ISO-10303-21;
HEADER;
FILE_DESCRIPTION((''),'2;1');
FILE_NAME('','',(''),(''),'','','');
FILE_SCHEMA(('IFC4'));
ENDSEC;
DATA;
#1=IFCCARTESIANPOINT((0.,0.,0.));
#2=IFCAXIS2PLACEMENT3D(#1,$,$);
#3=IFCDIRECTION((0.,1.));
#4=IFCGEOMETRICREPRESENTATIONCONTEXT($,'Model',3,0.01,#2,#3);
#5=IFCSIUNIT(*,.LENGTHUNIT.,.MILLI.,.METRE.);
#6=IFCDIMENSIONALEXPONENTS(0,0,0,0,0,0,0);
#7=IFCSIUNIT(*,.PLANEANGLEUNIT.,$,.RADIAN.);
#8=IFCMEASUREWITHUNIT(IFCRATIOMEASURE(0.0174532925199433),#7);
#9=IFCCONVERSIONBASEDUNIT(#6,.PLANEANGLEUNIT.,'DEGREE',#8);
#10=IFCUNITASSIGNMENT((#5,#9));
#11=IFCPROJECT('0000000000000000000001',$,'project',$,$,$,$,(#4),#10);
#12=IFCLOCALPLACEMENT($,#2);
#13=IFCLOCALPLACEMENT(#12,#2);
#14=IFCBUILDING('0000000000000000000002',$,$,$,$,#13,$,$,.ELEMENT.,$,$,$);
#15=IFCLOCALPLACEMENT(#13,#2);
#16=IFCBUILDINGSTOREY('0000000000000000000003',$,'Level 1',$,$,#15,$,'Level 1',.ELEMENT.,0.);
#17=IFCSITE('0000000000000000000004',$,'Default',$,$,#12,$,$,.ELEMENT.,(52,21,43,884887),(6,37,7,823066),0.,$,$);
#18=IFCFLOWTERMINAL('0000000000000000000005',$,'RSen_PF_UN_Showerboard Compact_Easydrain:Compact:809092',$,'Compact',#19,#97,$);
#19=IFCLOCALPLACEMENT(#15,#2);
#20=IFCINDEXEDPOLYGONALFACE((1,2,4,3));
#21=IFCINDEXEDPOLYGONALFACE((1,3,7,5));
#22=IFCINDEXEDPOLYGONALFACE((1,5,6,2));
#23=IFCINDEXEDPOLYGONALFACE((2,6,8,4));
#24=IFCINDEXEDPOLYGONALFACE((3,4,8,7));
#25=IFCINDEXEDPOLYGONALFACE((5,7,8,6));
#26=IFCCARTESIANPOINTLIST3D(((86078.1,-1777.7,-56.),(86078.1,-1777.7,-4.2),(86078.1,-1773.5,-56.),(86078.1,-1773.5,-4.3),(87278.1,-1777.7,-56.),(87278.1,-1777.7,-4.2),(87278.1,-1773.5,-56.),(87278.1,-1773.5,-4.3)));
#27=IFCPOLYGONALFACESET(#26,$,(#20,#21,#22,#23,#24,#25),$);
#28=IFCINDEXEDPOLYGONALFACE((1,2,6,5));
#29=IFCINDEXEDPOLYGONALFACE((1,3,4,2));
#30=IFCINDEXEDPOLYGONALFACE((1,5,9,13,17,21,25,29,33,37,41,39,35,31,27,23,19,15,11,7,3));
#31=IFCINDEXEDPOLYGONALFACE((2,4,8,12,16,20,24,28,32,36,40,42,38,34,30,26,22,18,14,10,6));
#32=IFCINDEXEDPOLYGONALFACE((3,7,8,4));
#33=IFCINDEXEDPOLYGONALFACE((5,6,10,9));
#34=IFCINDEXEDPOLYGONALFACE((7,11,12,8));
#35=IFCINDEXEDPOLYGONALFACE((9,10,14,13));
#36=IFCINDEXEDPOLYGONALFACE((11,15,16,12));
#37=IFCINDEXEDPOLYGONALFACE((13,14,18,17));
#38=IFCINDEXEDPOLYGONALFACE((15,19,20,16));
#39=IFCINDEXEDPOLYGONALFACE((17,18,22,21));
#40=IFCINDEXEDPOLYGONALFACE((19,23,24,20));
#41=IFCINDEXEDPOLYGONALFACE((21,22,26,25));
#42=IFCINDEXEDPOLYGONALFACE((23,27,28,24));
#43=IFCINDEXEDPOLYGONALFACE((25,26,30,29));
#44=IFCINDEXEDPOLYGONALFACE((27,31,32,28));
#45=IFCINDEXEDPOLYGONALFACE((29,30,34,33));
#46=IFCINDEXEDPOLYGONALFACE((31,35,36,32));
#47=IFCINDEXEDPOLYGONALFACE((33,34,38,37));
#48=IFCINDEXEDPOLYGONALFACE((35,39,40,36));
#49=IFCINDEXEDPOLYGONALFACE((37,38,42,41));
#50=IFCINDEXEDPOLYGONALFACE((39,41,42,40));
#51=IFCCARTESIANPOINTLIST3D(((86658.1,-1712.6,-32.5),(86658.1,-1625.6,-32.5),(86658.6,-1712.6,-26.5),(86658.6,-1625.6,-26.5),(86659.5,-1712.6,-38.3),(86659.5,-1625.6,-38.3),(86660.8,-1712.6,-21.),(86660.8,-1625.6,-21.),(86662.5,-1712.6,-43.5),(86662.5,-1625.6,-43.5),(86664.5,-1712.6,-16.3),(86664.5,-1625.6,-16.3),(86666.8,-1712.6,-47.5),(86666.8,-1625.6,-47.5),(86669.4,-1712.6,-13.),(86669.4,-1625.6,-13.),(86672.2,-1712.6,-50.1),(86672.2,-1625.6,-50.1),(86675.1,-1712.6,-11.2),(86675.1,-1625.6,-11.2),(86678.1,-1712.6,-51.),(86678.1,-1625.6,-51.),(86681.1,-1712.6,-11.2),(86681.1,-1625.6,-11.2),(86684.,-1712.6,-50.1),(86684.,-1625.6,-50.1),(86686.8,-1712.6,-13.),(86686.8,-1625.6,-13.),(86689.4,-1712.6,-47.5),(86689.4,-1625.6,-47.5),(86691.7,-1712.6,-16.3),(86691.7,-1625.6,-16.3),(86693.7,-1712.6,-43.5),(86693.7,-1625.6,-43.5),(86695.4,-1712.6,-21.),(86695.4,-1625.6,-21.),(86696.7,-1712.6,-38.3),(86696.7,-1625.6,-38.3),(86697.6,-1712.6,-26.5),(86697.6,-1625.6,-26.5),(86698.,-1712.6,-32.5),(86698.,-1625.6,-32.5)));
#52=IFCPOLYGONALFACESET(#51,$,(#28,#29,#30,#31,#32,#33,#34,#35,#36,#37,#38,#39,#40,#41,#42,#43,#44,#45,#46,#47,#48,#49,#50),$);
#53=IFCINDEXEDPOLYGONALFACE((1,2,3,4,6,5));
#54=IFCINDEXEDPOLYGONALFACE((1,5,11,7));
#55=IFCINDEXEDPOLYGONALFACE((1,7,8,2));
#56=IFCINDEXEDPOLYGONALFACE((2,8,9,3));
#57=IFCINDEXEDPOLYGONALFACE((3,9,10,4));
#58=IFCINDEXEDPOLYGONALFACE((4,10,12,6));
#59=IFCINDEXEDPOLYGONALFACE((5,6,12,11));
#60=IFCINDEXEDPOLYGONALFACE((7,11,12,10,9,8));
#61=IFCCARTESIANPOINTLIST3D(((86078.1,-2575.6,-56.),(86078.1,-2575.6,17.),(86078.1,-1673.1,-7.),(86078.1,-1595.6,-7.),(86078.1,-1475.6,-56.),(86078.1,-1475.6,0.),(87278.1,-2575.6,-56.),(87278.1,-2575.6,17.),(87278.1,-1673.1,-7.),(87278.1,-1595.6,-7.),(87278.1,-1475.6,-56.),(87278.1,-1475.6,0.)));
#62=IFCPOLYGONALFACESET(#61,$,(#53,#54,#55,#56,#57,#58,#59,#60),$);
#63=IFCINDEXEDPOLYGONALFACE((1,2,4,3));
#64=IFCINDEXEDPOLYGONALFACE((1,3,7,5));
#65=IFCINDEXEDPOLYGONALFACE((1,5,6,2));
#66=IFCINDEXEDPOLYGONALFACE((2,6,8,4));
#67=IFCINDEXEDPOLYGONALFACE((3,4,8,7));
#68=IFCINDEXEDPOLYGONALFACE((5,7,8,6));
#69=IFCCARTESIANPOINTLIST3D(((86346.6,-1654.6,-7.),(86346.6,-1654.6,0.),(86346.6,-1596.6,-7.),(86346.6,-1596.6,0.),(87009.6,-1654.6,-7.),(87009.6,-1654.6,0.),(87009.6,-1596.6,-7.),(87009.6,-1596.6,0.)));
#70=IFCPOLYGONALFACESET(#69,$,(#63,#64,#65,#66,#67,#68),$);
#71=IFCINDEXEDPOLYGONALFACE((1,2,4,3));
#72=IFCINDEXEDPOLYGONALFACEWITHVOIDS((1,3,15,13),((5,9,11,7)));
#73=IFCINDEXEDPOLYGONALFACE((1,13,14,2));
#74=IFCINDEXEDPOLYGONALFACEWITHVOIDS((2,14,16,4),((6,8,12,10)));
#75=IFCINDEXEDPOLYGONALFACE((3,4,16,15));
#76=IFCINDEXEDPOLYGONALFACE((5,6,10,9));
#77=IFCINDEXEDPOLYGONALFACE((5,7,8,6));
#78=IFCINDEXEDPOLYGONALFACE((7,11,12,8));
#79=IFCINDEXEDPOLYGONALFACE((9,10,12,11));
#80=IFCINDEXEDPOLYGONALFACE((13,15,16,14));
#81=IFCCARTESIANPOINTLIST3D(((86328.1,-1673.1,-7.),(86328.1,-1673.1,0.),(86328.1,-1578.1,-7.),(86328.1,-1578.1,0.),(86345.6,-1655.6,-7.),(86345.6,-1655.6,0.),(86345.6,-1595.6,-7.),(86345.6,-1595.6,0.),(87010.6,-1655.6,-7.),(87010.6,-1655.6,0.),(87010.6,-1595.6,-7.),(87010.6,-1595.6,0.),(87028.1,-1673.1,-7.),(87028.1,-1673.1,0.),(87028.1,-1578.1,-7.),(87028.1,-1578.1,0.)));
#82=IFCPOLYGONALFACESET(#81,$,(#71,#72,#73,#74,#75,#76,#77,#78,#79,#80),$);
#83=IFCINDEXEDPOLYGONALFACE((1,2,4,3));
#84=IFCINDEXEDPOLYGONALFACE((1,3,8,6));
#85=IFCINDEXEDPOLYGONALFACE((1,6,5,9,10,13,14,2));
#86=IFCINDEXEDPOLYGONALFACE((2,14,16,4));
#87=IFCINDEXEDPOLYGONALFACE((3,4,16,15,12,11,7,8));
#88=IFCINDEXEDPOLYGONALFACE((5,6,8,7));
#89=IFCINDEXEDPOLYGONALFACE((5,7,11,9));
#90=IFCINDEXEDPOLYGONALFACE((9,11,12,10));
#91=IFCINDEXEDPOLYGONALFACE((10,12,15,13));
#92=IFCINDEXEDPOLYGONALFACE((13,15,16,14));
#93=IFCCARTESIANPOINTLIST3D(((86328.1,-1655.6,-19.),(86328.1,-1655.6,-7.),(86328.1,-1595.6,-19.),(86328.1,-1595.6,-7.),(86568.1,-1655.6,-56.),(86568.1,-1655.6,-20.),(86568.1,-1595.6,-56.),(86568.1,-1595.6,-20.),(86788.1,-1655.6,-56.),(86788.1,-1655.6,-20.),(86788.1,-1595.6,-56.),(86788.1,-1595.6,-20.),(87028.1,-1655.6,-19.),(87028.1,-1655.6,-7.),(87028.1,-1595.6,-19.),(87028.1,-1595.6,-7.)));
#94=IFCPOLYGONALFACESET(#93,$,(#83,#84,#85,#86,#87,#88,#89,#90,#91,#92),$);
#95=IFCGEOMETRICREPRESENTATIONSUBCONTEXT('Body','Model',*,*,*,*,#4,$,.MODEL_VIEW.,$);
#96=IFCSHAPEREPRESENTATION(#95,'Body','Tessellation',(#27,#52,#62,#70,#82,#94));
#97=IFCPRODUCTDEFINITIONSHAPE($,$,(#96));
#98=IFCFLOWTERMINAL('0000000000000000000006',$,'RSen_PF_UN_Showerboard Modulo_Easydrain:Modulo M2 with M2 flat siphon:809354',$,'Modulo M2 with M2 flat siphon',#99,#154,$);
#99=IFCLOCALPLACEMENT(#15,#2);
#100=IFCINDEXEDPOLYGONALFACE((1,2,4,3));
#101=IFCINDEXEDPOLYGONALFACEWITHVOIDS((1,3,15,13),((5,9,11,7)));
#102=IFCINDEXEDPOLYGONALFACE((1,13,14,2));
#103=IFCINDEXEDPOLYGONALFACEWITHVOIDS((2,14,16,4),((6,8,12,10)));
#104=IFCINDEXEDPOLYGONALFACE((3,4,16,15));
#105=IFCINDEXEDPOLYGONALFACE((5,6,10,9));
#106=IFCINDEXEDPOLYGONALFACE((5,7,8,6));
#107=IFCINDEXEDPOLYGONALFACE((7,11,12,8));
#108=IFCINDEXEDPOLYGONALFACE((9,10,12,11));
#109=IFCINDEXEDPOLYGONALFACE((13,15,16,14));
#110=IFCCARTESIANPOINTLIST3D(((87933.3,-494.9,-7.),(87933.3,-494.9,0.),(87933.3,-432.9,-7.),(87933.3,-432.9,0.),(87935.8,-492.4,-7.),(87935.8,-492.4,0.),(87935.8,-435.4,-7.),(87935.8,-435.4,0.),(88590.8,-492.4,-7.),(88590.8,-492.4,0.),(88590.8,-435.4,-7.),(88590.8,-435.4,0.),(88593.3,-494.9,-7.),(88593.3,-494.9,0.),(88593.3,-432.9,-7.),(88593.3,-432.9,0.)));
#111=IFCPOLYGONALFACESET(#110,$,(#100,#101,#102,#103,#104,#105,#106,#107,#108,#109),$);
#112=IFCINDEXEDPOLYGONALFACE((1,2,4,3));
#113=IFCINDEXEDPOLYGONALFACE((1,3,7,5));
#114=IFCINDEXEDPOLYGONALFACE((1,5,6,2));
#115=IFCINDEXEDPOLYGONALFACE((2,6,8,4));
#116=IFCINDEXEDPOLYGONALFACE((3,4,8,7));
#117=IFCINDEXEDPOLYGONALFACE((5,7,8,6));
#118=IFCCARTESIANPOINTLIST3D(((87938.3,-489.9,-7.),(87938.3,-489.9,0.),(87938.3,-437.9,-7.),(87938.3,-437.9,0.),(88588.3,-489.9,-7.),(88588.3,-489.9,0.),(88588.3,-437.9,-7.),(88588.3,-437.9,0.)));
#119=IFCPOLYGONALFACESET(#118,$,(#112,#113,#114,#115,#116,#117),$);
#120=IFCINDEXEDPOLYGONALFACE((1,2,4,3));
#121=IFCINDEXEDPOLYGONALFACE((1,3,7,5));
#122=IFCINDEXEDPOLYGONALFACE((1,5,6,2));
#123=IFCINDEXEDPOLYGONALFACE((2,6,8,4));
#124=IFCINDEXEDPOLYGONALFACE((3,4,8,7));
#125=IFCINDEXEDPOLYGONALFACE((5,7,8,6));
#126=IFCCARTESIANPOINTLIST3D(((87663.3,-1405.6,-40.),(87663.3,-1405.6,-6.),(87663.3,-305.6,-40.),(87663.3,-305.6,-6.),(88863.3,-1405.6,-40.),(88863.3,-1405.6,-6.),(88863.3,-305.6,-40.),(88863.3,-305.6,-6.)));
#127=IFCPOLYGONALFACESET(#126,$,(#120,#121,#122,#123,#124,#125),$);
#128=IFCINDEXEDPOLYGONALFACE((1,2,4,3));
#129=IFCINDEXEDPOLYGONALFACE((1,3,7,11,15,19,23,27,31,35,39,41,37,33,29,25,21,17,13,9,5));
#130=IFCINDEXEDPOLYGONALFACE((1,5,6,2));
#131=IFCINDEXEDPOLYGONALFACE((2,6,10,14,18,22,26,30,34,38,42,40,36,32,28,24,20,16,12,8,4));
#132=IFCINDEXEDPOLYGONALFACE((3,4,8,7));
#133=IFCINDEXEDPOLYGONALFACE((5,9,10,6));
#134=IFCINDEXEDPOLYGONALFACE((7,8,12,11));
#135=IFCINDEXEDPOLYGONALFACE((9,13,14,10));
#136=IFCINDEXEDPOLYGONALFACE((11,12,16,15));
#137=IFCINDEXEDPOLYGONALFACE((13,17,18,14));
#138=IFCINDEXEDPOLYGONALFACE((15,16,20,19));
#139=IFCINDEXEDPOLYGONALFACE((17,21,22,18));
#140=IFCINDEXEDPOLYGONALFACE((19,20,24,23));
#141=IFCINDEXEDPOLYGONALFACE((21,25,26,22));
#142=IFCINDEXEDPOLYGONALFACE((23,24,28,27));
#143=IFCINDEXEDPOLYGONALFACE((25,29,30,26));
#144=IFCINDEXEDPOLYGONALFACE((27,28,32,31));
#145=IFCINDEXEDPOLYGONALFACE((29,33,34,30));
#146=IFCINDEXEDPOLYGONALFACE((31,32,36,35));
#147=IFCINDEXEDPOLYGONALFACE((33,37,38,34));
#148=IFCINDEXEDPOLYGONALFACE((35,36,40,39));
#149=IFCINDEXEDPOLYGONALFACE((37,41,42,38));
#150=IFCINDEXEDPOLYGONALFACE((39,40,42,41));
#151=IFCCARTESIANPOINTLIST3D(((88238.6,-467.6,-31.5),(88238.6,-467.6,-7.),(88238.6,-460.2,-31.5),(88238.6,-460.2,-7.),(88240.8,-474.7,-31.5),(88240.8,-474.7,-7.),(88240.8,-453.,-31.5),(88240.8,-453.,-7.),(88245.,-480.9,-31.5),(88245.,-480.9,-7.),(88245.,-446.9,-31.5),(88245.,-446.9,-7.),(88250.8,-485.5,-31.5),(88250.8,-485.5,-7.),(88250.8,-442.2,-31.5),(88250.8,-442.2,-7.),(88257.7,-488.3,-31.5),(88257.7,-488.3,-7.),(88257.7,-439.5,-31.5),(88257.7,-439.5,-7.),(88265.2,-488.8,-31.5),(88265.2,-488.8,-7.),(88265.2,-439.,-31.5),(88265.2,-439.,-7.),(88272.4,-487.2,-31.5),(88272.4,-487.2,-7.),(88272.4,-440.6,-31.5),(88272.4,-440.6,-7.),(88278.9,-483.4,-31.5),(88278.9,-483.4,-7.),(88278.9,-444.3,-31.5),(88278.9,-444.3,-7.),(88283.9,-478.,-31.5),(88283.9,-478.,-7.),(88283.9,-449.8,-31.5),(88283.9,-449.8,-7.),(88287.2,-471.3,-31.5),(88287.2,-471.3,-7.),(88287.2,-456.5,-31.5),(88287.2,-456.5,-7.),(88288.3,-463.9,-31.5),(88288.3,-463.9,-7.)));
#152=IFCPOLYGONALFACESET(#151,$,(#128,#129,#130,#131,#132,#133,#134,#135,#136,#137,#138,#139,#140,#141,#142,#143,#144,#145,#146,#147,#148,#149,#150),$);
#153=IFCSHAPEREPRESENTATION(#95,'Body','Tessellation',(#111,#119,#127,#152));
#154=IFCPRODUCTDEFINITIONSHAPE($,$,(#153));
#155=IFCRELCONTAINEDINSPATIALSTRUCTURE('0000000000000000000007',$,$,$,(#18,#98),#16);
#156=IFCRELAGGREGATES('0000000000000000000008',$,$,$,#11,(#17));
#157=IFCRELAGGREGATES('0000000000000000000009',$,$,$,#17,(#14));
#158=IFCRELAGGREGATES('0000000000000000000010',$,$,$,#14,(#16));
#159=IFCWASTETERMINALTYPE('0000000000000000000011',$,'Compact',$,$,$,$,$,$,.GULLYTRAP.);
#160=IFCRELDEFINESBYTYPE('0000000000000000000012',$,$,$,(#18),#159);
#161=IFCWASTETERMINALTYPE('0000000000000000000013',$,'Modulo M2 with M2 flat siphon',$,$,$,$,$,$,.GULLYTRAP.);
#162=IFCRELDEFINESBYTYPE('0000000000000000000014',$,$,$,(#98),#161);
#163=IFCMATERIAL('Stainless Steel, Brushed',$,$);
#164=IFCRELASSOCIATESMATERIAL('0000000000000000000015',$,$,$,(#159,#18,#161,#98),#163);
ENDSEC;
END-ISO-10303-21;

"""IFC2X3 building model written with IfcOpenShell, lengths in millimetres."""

from ifc_helpers import new_model, entity, si_unit, converted_unit, direction, frame, frame_2d, origin, origin_2d_with_axis, place, context, subcontext, project, spatial, polyline, rectangle, circle, outline, extrude, source, transform, mapped, material, type_object, type_shapes, element, save


model = new_model("IFC2X3")

# Units and contexts
model_context = context("Model", 3, precision=0.01, world=origin(), true_north=direction((0.0, 1.0)))
body_context = subcontext(model_context, "Body", "Model", "MODEL_VIEW")
ifc_project = project(units=[si_unit("LENGTHUNIT", "METRE", prefix="MILLI"), converted_unit("PLANEANGLEUNIT", "DEGREE", entity("IfcRatioMeasure", 0.0174532925199433), si_unit("PLANEANGLEUNIT", "RADIAN"), dimensions=[0, 0, 0, 0, 0, 0, 0])], contexts=[model_context])

# Site, building, storey
site_placement = place(None, origin())
site = spatial("IfcSite", under=ifc_project, at=site_placement, Name="Default", CompositionType="ELEMENT", RefLatitude=(52, 21, 43, 884887), RefLongitude=(6, 37, 7, 823066), RefElevation=0.0)
building_placement = place(site_placement, origin())
building = spatial("IfcBuilding", under=site, at=building_placement, CompositionType="ELEMENT")
storey_placement = place(building_placement, origin())
storey = spatial("IfcBuildingStorey", under=building, at=storey_placement, Name="Level 1", LongName="Level 1", CompositionType="ELEMENT", Elevation=0.0)

# Flow terminals
ifc_material_1 = material(Name="Stainless Steel, Brushed")
waste_terminal_type_1 = type_object("IfcWasteTerminalType", Name="Compact", PredefinedType="GULLYTRAP", material=ifc_material_1)
shared_shape_1 = source(origin(), body_context, "Body", "SweptSolid", [
    extrude(outline(polyline([(-1.4, -25.9), (2.8, -25.9), (1.4, 25.9), (-2.8, 25.8), (-1.4, -25.9)])), frame((-517.5, -150.0, -30.1), z_axis=(1.0, 0.0, 0.0), x_axis=(0.0, -0.999647, 0.026583)), (0.0, 0.0, 1.0), 1200.0),
    extrude(circle(Radius=20.0, at=frame_2d((0.0, 0.0), x_axis=(1.0, 0.0))), frame((82.5, -87.0, -31.0), z_axis=(0.0, 1.0, 0.0), x_axis=(0.0, 0.0, -1.0)), (0.0, 0.0, 1.0), 87.0),
    extrude(outline(polyline([(-37.8, -419.6), (18.2, -419.6), (11.2, -299.6), (11.2, -222.1), (35.2, 680.4), (-37.8, 680.4), (-37.8, -419.6)])), frame((-517.5, -269.6, -18.2), z_axis=(1.0, 0.0, 0.0), x_axis=(0.0, 0.0, 1.0)), (0.0, 0.0, 1.0), 1200.0),
    extrude(rectangle(XDim=663.0, YDim=58.0, at=origin_2d_with_axis()), frame((82.5, 0.0, -7.0), z_axis=(0.0, 0.0, 1.0), x_axis=(-1.0, 0.0, 0.0)), (0.0, 0.0, 1.0), 7.0),
    extrude(outline(polyline([(-350.0, -47.5), (350.0, -47.5), (350.0, 47.5), (-350.0, 47.5), (-350.0, -47.5)]), holes=[polyline([(-332.5, -30.0), (-332.5, 30.0), (332.5, 30.0), (332.5, -30.0), (-332.5, -30.0)])]), frame((82.5, 0.0, -7.0), z_axis=(0.0, 0.0, 1.0), x_axis=(-1.0, 0.0, 0.0)), (0.0, 0.0, 1.0), 7.0),
    extrude(outline(polyline([(6.5, -350.0), (18.5, -350.0), (18.5, 350.0), (6.5, 350.0), (5.5, 110.0), (-30.5, 110.0), (-30.5, -110.0), (5.5, -110.0), (6.5, -350.0)])), frame((82.5, -30.0, -25.5), z_axis=(0.0, 1.0, 0.0), x_axis=(0.0, 0.0, 1.0)), (0.0, 0.0, 1.0), 60.0),
])
type_shapes(waste_terminal_type_1, [shared_shape_1])
flow_terminal_1_placement = place(storey_placement, frame((86595.6, -1625.6, 0.0)))
element("IfcFlowTerminal", 1, at=flow_terminal_1_placement, inside=storey, type_object=waste_terminal_type_1, material=ifc_material_1, Name="RSen_PF_UN_Showerboard Compact_Easydrain:Compact:809092", ObjectType="Compact", context=body_context, shape_type="MappedRepresentation", body=[
    mapped(shared_shape_1, transform((0.0, 0.0, 0.0), scale=1.0)),
])
waste_terminal_type_2 = type_object("IfcWasteTerminalType", Name="Modulo M2 with M2 flat siphon", PredefinedType="GULLYTRAP", material=ifc_material_1)
shared_shape_2 = source(origin(), body_context, "Body", "SweptSolid", [
    extrude(outline(polyline([(-330.0, -31.0), (330.0, -31.0), (330.0, 31.0), (-330.0, 31.0), (-330.0, -31.0)]), holes=[polyline([(-327.5, -28.5), (-327.5, 28.5), (327.5, 28.5), (327.5, -28.5), (-327.5, -28.5)])]), frame((0.0, -21.0, -7.0), z_axis=(0.0, 0.0, 1.0), x_axis=(-1.0, 0.0, 0.0)), (0.0, 0.0, 1.0), 7.0),
    extrude(rectangle(XDim=650.0, YDim=52.0, at=origin_2d_with_axis()), frame((0.0, -21.0, -7.0), z_axis=(0.0, 0.0, 1.0), x_axis=(-1.0, 0.0, 0.0)), (0.0, 0.0, 1.0), 7.0),
    extrude(rectangle(XDim=1200.0, YDim=1100.0, at=origin_2d_with_axis()), frame((0.0, -412.7, -40.0), z_axis=(0.0, 0.0, 1.0), x_axis=(-1.0, 0.0, 0.0)), (0.0, 0.0, 1.0), 34.0),
    extrude(circle(Radius=25.0, at=frame_2d((0.0, 0.0), x_axis=(1.0, 0.0))), frame((0.0, -21.0, -31.5)), (0.0, 0.0, 1.0), 24.5),
])
type_shapes(waste_terminal_type_2, [shared_shape_2])
flow_terminal_2_placement = place(storey_placement, frame((88263.3, -442.9, 0.0)))
element("IfcFlowTerminal", 2, at=flow_terminal_2_placement, inside=storey, type_object=waste_terminal_type_2, material=ifc_material_1, Name="RSen_PF_UN_Showerboard Modulo_Easydrain:Modulo M2 with M2 flat siphon:809354", ObjectType="Modulo M2 with M2 flat siphon", context=body_context, shape_type="MappedRepresentation", body=[
    mapped(shared_shape_2, transform((0.0, 0.0, 0.0), scale=1.0)),
])

save(model, "model.ifc")
